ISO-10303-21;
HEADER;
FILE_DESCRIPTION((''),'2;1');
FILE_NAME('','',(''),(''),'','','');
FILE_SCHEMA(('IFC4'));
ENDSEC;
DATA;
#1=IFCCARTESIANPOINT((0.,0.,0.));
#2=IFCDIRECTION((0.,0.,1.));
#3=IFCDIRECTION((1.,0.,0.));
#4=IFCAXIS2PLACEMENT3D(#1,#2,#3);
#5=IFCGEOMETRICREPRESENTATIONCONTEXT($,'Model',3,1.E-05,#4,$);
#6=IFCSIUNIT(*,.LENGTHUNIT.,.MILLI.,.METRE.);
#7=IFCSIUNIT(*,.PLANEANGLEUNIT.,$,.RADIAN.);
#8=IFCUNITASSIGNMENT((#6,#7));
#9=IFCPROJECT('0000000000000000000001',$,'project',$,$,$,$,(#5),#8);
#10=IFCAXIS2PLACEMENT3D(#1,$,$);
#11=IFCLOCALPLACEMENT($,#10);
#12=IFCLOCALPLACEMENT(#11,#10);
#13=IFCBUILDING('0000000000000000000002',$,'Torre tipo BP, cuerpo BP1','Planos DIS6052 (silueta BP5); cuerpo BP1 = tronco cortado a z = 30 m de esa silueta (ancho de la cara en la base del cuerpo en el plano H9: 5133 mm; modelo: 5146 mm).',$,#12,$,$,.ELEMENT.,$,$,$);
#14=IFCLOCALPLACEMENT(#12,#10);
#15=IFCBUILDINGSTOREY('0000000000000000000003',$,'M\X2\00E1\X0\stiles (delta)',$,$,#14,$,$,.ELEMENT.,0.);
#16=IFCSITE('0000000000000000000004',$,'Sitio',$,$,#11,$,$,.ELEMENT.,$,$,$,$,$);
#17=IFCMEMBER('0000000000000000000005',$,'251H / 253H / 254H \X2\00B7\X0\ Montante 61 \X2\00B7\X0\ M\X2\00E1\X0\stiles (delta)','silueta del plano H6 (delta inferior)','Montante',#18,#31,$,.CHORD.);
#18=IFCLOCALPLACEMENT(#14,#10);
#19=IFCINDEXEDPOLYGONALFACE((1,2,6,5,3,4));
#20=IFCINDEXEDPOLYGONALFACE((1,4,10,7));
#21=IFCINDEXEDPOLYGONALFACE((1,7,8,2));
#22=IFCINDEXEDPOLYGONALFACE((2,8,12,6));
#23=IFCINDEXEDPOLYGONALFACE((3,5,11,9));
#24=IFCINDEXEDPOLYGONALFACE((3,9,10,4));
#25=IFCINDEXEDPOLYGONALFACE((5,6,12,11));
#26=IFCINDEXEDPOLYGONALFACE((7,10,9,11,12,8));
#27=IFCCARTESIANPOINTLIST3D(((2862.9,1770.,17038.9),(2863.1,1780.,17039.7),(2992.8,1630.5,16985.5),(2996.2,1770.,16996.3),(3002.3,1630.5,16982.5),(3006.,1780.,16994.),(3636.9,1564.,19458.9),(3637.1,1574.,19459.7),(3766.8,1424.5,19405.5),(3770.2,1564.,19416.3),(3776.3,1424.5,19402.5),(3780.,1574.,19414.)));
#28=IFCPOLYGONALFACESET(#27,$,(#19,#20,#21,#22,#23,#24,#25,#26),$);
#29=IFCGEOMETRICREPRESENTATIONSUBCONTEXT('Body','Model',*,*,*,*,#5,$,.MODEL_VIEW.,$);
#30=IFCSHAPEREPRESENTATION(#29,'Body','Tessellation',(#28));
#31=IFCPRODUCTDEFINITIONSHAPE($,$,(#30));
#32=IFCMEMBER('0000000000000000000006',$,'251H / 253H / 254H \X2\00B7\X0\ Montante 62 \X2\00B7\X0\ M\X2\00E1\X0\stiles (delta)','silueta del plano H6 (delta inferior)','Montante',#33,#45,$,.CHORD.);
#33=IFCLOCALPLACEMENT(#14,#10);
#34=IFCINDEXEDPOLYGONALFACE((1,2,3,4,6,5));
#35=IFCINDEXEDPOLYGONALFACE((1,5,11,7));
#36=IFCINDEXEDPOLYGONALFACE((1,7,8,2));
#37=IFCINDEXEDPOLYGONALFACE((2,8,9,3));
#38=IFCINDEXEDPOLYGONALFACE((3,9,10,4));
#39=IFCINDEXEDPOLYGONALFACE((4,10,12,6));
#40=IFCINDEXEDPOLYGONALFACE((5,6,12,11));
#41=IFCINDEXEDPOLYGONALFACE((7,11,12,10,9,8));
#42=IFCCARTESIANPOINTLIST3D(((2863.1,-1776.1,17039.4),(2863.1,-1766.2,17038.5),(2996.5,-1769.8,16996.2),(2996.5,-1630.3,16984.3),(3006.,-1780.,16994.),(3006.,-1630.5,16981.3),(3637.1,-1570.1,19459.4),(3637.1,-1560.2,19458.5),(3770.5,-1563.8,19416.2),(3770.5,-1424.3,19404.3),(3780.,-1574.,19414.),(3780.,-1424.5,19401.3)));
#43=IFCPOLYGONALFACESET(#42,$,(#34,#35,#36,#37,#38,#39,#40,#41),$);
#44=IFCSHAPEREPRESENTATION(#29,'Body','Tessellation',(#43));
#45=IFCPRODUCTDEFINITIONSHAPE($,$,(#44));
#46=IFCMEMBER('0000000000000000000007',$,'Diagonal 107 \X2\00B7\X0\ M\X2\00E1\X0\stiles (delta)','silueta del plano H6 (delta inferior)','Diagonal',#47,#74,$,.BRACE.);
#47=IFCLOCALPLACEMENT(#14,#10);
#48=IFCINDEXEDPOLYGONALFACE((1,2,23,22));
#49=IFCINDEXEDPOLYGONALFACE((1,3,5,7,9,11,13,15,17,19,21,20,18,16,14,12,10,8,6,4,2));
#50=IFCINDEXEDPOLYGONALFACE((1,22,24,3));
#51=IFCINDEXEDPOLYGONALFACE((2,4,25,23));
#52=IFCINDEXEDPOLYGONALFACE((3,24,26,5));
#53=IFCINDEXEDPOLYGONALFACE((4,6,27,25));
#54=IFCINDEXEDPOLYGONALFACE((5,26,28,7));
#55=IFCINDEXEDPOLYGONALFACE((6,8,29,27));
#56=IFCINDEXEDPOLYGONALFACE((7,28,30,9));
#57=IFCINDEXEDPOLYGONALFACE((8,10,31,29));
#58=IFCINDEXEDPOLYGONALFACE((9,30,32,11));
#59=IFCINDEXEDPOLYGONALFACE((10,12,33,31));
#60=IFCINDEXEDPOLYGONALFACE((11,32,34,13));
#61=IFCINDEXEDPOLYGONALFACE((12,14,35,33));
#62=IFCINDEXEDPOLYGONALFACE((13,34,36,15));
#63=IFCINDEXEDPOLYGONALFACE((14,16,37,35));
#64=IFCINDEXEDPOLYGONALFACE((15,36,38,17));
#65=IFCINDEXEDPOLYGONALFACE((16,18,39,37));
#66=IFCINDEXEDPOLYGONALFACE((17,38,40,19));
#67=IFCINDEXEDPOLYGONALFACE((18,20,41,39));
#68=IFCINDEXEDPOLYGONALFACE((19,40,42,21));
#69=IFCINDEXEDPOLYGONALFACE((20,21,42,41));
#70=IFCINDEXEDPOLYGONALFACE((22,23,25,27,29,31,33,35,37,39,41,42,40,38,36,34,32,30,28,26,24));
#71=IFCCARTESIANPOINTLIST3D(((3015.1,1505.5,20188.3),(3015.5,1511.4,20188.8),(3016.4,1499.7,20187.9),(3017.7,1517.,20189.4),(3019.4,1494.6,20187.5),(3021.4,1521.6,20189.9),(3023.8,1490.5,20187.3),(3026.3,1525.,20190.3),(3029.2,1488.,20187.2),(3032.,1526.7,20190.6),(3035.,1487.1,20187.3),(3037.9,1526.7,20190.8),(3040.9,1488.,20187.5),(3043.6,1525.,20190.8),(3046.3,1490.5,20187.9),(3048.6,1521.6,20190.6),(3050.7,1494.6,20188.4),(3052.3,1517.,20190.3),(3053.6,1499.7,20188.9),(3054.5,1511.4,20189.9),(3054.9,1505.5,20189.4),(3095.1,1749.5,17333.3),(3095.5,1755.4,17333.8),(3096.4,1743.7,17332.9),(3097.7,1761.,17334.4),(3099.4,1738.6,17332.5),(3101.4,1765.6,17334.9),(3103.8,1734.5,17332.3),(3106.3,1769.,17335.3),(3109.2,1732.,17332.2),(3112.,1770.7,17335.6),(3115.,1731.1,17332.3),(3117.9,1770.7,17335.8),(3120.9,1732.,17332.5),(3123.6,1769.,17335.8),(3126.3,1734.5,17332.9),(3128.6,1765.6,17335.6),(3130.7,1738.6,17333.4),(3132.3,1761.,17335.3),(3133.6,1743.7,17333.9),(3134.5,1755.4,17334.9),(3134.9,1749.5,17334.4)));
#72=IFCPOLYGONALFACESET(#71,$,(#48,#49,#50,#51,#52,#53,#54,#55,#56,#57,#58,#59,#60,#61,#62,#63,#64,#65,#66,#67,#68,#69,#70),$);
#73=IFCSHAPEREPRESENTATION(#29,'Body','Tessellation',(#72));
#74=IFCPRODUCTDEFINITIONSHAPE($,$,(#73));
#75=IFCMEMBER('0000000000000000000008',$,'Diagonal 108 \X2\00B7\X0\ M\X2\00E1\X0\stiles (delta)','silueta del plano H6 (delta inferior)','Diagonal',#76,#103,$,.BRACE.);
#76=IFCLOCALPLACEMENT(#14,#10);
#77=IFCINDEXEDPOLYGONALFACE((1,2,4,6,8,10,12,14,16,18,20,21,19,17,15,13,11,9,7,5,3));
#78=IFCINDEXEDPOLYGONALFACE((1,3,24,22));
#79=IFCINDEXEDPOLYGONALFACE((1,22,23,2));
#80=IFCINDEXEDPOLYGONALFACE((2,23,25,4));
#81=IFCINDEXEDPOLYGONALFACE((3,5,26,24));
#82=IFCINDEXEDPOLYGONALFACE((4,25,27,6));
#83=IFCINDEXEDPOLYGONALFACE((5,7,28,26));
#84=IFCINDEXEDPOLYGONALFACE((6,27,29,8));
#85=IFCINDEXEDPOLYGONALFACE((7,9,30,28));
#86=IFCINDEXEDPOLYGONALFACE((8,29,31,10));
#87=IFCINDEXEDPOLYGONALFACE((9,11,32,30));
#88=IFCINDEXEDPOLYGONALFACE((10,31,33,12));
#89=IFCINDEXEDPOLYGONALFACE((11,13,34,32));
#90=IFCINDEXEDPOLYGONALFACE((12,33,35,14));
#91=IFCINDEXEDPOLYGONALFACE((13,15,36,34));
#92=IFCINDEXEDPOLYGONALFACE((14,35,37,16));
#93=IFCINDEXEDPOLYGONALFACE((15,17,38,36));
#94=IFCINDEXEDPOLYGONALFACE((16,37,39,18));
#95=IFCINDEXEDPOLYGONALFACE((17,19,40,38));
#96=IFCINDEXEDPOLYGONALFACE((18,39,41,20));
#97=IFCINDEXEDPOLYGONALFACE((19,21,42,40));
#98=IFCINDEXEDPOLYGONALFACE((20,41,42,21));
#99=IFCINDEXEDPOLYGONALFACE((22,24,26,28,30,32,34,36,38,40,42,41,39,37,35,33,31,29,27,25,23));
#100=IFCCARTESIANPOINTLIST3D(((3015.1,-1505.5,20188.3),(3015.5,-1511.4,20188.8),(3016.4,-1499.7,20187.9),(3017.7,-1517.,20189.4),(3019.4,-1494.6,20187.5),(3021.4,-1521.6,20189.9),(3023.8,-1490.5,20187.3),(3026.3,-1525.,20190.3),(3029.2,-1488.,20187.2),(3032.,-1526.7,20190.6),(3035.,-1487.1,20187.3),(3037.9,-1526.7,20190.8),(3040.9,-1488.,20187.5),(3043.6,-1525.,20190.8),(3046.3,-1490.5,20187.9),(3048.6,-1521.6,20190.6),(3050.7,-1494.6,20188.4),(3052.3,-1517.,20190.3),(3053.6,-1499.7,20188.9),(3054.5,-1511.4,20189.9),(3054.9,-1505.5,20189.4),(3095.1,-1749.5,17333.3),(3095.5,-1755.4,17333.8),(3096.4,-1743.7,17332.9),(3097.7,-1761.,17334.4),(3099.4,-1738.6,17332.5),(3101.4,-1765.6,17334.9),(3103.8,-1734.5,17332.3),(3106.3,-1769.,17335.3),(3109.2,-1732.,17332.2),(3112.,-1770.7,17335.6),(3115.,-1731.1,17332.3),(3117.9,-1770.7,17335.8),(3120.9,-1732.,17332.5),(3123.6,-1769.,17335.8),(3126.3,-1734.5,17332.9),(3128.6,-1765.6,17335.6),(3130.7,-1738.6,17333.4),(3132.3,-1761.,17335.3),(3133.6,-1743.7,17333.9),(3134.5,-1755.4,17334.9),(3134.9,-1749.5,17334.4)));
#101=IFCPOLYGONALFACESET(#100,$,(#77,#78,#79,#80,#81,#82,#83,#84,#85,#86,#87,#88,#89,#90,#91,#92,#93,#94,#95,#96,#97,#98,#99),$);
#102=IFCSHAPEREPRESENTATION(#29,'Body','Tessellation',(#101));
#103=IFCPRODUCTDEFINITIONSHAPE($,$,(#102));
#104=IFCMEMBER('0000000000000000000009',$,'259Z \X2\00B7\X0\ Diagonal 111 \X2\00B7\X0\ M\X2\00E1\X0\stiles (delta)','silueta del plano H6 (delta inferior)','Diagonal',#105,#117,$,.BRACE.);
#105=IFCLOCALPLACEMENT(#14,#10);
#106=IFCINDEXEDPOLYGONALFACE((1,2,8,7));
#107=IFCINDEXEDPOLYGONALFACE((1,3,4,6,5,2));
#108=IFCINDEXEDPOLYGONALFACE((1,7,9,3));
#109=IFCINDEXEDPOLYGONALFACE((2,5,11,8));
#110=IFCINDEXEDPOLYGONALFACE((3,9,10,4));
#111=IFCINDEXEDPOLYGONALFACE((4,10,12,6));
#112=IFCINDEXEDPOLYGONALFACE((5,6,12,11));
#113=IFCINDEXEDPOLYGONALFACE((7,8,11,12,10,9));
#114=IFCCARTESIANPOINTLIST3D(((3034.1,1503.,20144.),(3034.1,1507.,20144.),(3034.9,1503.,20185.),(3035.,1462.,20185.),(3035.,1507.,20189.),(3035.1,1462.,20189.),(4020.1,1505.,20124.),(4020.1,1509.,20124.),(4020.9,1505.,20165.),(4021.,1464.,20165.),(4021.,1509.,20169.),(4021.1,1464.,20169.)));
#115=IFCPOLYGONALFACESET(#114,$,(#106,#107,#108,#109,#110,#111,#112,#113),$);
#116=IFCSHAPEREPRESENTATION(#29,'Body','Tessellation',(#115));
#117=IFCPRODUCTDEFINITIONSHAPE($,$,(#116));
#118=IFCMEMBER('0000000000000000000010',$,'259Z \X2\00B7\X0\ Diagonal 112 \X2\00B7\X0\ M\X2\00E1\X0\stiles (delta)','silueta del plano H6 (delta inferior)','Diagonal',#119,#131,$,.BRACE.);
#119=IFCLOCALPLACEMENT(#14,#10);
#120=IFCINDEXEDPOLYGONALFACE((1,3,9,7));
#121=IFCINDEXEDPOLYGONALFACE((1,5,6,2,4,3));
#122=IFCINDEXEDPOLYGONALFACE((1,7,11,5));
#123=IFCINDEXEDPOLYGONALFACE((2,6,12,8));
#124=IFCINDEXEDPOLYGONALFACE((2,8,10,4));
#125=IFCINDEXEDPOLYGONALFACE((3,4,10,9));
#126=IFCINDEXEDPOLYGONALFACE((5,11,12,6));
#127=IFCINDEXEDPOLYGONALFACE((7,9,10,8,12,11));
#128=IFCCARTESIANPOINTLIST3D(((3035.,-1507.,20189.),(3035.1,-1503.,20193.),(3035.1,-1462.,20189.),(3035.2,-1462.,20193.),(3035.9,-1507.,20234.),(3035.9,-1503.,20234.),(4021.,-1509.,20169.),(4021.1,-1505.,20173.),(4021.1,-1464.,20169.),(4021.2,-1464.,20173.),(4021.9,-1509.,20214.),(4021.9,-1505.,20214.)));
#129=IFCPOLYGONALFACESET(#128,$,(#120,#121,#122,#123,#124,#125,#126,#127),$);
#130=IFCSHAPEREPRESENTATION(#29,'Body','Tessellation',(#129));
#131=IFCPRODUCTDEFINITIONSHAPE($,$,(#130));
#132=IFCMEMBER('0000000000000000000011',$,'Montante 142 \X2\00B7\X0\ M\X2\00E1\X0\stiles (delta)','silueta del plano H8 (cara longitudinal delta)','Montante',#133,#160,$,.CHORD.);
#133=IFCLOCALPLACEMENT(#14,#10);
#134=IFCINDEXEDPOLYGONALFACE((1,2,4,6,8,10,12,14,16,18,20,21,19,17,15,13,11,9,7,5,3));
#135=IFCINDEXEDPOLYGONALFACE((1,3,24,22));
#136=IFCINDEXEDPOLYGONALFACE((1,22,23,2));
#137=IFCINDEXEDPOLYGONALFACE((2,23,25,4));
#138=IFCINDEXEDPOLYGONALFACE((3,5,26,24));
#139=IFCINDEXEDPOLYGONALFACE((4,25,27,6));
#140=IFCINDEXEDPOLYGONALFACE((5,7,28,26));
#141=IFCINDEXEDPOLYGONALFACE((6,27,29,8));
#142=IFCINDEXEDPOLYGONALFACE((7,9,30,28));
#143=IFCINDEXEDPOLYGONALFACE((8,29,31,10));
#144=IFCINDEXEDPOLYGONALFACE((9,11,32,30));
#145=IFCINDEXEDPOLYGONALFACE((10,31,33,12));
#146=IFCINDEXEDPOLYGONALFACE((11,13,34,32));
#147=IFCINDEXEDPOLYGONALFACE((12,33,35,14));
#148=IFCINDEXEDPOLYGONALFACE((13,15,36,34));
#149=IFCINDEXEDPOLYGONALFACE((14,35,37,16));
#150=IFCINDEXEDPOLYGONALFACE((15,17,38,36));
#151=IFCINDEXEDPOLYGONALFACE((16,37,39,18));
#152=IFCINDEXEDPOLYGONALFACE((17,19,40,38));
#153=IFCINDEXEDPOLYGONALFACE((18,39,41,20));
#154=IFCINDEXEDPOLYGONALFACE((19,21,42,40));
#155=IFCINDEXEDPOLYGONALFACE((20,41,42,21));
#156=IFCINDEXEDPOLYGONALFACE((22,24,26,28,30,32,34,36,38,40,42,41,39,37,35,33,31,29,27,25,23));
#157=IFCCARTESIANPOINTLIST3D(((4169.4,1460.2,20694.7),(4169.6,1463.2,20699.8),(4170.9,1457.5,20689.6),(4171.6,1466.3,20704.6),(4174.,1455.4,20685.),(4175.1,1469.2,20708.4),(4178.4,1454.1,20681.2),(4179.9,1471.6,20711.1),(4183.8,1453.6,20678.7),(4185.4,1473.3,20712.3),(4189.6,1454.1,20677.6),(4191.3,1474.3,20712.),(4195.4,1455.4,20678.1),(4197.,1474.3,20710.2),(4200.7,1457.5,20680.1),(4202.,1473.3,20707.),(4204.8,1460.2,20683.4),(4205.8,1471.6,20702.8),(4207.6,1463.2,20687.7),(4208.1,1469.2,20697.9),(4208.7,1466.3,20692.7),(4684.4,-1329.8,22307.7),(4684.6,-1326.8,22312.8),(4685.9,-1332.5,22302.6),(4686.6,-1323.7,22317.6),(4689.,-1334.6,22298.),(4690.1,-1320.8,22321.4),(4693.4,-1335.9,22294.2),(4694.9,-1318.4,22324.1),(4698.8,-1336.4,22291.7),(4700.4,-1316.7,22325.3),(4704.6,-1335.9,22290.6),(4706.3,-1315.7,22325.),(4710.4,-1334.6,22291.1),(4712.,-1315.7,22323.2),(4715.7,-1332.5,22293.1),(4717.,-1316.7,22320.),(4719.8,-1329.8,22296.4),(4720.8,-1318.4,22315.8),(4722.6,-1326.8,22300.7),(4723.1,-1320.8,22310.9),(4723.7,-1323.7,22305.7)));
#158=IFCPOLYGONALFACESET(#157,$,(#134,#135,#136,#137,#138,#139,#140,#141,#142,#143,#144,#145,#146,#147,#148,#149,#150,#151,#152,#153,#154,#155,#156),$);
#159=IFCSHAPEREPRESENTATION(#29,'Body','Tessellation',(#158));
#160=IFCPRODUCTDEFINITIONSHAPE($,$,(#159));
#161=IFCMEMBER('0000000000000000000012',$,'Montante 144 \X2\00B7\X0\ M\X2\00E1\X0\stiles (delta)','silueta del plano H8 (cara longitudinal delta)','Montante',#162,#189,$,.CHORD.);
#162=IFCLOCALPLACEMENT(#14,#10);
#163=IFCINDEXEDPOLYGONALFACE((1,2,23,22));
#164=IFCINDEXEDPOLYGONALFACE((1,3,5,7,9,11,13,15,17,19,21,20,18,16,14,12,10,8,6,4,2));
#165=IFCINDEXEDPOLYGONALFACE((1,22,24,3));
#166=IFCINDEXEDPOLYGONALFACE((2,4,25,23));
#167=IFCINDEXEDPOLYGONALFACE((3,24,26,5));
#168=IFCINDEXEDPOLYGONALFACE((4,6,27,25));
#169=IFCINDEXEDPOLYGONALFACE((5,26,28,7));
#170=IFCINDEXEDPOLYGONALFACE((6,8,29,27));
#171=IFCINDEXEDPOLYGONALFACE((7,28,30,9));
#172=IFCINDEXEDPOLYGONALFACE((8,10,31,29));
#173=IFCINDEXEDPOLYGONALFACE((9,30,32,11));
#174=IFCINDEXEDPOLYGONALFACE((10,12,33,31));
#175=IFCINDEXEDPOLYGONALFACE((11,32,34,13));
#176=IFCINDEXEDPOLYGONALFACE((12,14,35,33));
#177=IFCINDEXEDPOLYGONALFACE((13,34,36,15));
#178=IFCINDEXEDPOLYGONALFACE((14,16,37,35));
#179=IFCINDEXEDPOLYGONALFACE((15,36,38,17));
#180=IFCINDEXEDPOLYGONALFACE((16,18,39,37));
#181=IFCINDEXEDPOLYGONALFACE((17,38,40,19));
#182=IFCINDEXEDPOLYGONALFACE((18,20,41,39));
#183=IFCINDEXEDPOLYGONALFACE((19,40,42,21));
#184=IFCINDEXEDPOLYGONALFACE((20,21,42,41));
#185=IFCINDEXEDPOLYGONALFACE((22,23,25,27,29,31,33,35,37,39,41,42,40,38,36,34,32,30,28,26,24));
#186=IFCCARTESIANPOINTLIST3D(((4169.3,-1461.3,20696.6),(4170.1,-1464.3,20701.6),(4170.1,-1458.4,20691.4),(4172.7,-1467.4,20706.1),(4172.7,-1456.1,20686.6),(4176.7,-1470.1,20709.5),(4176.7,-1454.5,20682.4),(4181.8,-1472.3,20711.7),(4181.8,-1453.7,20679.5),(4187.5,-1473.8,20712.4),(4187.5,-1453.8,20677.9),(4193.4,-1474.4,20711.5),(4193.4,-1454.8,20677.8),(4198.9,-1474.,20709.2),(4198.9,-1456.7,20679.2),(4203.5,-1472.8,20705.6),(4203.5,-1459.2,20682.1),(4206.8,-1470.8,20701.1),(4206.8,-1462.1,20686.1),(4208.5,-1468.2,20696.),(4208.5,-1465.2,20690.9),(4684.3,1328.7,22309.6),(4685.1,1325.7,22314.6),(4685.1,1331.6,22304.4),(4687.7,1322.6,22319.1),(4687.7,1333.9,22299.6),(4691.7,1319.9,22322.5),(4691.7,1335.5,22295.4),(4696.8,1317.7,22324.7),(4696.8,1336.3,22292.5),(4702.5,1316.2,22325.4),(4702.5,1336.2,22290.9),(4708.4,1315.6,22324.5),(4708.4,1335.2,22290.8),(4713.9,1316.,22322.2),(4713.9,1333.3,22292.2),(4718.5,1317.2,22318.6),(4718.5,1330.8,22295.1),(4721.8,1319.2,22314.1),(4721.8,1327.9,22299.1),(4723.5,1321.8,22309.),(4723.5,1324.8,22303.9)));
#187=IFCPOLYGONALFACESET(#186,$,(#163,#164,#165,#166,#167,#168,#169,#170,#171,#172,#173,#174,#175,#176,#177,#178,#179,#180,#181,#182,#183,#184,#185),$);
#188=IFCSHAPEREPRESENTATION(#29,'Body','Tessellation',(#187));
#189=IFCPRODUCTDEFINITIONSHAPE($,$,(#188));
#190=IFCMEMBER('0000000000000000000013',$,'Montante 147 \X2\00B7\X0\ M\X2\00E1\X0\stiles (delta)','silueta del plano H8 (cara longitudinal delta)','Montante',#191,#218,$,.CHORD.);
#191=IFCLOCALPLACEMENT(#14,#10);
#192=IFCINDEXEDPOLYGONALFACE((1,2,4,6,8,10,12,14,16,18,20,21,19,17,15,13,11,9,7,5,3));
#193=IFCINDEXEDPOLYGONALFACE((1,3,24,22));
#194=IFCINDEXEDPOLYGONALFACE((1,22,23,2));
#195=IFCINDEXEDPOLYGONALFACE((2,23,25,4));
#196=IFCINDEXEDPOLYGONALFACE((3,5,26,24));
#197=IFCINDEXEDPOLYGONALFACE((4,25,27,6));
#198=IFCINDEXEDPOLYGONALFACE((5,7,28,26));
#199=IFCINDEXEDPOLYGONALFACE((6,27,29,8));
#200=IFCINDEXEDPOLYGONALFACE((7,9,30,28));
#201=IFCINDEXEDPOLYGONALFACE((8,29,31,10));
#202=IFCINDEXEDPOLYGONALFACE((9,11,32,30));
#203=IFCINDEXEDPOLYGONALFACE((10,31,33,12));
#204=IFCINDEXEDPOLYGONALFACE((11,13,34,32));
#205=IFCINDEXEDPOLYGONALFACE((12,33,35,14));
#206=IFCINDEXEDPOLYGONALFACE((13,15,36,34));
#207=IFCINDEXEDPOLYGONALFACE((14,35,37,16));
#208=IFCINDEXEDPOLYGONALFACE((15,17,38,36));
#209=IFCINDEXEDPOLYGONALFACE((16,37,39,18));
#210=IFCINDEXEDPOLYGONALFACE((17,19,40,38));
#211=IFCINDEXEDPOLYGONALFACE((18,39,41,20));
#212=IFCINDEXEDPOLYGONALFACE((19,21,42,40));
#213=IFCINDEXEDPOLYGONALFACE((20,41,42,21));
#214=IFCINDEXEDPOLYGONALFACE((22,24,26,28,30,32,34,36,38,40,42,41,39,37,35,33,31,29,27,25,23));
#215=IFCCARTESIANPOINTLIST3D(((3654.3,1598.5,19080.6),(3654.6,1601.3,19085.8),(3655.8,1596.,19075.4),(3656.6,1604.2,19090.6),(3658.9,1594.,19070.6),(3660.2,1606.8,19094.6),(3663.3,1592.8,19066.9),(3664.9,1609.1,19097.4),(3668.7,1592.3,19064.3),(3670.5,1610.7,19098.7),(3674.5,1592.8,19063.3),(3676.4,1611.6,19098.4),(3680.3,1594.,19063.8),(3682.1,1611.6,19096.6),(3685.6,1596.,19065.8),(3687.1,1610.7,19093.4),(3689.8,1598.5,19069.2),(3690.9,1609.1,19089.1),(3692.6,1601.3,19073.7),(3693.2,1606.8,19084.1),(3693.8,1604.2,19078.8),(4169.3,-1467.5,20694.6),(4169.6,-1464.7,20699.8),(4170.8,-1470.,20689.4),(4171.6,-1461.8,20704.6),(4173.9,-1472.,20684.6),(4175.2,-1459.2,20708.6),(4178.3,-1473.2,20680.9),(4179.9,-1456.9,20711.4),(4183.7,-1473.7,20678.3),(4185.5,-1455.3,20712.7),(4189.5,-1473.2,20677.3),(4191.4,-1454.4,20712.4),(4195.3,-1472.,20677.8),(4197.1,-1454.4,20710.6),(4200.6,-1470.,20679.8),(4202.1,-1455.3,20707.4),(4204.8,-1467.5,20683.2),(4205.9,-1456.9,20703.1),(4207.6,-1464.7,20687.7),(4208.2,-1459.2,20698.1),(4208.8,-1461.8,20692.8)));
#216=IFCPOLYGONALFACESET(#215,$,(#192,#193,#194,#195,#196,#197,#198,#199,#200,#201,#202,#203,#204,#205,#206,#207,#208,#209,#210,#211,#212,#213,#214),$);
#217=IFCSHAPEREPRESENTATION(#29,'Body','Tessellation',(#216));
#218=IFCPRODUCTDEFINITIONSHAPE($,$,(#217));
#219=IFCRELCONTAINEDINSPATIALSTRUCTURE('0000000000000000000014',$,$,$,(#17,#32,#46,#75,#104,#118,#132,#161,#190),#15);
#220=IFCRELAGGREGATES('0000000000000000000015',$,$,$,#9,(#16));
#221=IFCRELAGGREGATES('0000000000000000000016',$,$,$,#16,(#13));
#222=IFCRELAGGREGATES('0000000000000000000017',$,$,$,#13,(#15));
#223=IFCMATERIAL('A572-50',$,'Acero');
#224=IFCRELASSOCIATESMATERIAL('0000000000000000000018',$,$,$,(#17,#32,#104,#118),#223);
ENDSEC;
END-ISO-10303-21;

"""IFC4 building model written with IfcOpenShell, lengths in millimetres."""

from ifc_helpers import new_model, si_unit, frame, frame_2d, origin, origin_with_axes, place, context, subcontext, project, spatial, circle, l_section, extrude, material, element, save


model = new_model("IFC4")

# Units and contexts
model_context = context("Model", 3, precision=1e-05, world=origin_with_axes())
body_context = subcontext(model_context, "Body", "Model", "MODEL_VIEW")
ifc_project = project(units=[si_unit("LENGTHUNIT", "METRE", prefix="MILLI"), si_unit("PLANEANGLEUNIT", "RADIAN")], contexts=[model_context])

# Site, building, storey
site_placement = place(None, origin())
site = spatial("IfcSite", under=ifc_project, at=site_placement, Name="Sitio", CompositionType="ELEMENT")
building_placement = place(site_placement, origin())
building = spatial("IfcBuilding", under=site, at=building_placement, Name="Torre tipo BP, cuerpo BP1", Description="Planos DIS6052 (silueta BP5); cuerpo BP1 = tronco cortado a z = 30 m de esa silueta (ancho de la cara en la base del cuerpo en el plano H9: 5133 mm; modelo: 5146 mm).", CompositionType="ELEMENT")
storey_placement = place(building_placement, origin())
storey = spatial("IfcBuildingStorey", under=building, at=storey_placement, Name="Mástiles (delta)", CompositionType="ELEMENT", Elevation=0.0)

# Members
ifc_material = material(Name="A572-50", Category="Acero")
for number, where, z_axis, x_axis, name in (
    (1, (3780.0, 1574.0, 19414.0), (-0.303637, 0.080813, -0.949355), (-0.024618, -0.996729, -0.076972), "251H / 253H / 254H · Montante 61 · Mástiles (delta)"),
    (2, (3780.0, -1574.0, 19414.0), (-0.303637, -0.080813, -0.949355), (-0.952788, 0.025754, 0.302542), "251H / 253H / 254H · Montante 62 · Mástiles (delta)"),
):
    element("IfcMember", number, at=place(storey_placement, frame(where, z_axis=z_axis, x_axis=x_axis)), inside=storey, material=ifc_material, Name=name, Description="silueta del plano H6 (delta inferior)", ObjectType="Montante", PredefinedType="CHORD", context=body_context, shape_type="SweptSolid", body=[
        extrude(l_section(Depth=150.0, Width=150.0, Thickness=10.0, at=frame_2d((75.0, 75.0))), None, (0.0, 0.0, 1.0), 2549.1),
    ])
for number, where, z_axis, x_axis, name in (
    (3, (3035.0, 1507.0, 20189.0), (0.027908, 0.085121, -0.99598), (0.002384, -0.996371, -0.085087), "Diagonal 107 · Mástiles (delta)"),
    (4, (3035.0, -1507.0, 20189.0), (0.027908, -0.085121, -0.99598), (0.002384, 0.996371, -0.085087), "Diagonal 108 · Mástiles (delta)"),
):
    element("IfcMember", number, at=place(storey_placement, frame(where, z_axis=z_axis, x_axis=x_axis)), inside=storey, Name=name, Description="silueta del plano H6 (delta inferior)", ObjectType="Diagonal", PredefinedType="BRACE", context=body_context, shape_type="SweptSolid", body=[
        extrude(circle(Radius=20.0), None, (0.0, 0.0, 1.0), 2866.5),
    ])
for number, where, z_axis, x_axis, name in (
    (5, (3035.0, 1507.0, 20189.0), (0.999792, 0.002028, -0.02028), (0.002028, -0.999998, -0.000041), "259Z · Diagonal 111 · Mástiles (delta)"),
    (6, (3035.0, -1507.0, 20189.0), (0.999792, -0.002028, -0.02028), (0.002028, 0.999998, -0.000041), "259Z · Diagonal 112 · Mástiles (delta)"),
):
    element("IfcMember", number, at=place(storey_placement, frame(where, z_axis=z_axis, x_axis=x_axis)), inside=storey, material=ifc_material, Name=name, Description="silueta del plano H6 (delta inferior)", ObjectType="Diagonal", PredefinedType="BRACE", context=body_context, shape_type="SweptSolid", body=[
        extrude(l_section(Depth=45.0, Width=45.0, Thickness=4.0, at=frame_2d((22.5, 22.5))), None, (0.0, 0.0, 1.0), 986.2),
    ])
for number, where, z_axis, x_axis, name in (
    (7, (4704.0, -1326.0, 22308.0), (-0.157801, 0.854884, -0.494239), (-0.260017, -0.518819, -0.814382), "Montante 142 · Mástiles (delta)"),
    (8, (4704.0, 1326.0, 22308.0), (-0.157801, -0.854884, -0.494239), (-0.987471, 0.136613, 0.078981), "Montante 144 · Mástiles (delta)"),
):
    element("IfcMember", number, at=place(storey_placement, frame(where, z_axis=z_axis, x_axis=x_axis)), inside=storey, Name=name, Description="silueta del plano H8 (cara longitudinal delta)", ObjectType="Montante", PredefinedType="CHORD", context=body_context, shape_type="SweptSolid", body=[
        extrude(circle(Radius=20.0), None, (0.0, 0.0, 1.0), 3263.6),
    ])
member_1_placement = place(storey_placement, frame((4189.0, -1464.0, 20695.0), z_axis=(-0.147019, 0.875265, -0.460756), x_axis=(-0.266066, -0.483643, -0.833845)))
element("IfcMember", 9, at=member_1_placement, inside=storey, Name="Montante 147 · Mástiles (delta)", Description="silueta del plano H8 (cara longitudinal delta)", ObjectType="Montante", PredefinedType="CHORD", context=body_context, shape_type="SweptSolid", body=[
    extrude(circle(Radius=20.0), None, (0.0, 0.0, 1.0), 3502.9),
])

save(model, "model.ifc")
